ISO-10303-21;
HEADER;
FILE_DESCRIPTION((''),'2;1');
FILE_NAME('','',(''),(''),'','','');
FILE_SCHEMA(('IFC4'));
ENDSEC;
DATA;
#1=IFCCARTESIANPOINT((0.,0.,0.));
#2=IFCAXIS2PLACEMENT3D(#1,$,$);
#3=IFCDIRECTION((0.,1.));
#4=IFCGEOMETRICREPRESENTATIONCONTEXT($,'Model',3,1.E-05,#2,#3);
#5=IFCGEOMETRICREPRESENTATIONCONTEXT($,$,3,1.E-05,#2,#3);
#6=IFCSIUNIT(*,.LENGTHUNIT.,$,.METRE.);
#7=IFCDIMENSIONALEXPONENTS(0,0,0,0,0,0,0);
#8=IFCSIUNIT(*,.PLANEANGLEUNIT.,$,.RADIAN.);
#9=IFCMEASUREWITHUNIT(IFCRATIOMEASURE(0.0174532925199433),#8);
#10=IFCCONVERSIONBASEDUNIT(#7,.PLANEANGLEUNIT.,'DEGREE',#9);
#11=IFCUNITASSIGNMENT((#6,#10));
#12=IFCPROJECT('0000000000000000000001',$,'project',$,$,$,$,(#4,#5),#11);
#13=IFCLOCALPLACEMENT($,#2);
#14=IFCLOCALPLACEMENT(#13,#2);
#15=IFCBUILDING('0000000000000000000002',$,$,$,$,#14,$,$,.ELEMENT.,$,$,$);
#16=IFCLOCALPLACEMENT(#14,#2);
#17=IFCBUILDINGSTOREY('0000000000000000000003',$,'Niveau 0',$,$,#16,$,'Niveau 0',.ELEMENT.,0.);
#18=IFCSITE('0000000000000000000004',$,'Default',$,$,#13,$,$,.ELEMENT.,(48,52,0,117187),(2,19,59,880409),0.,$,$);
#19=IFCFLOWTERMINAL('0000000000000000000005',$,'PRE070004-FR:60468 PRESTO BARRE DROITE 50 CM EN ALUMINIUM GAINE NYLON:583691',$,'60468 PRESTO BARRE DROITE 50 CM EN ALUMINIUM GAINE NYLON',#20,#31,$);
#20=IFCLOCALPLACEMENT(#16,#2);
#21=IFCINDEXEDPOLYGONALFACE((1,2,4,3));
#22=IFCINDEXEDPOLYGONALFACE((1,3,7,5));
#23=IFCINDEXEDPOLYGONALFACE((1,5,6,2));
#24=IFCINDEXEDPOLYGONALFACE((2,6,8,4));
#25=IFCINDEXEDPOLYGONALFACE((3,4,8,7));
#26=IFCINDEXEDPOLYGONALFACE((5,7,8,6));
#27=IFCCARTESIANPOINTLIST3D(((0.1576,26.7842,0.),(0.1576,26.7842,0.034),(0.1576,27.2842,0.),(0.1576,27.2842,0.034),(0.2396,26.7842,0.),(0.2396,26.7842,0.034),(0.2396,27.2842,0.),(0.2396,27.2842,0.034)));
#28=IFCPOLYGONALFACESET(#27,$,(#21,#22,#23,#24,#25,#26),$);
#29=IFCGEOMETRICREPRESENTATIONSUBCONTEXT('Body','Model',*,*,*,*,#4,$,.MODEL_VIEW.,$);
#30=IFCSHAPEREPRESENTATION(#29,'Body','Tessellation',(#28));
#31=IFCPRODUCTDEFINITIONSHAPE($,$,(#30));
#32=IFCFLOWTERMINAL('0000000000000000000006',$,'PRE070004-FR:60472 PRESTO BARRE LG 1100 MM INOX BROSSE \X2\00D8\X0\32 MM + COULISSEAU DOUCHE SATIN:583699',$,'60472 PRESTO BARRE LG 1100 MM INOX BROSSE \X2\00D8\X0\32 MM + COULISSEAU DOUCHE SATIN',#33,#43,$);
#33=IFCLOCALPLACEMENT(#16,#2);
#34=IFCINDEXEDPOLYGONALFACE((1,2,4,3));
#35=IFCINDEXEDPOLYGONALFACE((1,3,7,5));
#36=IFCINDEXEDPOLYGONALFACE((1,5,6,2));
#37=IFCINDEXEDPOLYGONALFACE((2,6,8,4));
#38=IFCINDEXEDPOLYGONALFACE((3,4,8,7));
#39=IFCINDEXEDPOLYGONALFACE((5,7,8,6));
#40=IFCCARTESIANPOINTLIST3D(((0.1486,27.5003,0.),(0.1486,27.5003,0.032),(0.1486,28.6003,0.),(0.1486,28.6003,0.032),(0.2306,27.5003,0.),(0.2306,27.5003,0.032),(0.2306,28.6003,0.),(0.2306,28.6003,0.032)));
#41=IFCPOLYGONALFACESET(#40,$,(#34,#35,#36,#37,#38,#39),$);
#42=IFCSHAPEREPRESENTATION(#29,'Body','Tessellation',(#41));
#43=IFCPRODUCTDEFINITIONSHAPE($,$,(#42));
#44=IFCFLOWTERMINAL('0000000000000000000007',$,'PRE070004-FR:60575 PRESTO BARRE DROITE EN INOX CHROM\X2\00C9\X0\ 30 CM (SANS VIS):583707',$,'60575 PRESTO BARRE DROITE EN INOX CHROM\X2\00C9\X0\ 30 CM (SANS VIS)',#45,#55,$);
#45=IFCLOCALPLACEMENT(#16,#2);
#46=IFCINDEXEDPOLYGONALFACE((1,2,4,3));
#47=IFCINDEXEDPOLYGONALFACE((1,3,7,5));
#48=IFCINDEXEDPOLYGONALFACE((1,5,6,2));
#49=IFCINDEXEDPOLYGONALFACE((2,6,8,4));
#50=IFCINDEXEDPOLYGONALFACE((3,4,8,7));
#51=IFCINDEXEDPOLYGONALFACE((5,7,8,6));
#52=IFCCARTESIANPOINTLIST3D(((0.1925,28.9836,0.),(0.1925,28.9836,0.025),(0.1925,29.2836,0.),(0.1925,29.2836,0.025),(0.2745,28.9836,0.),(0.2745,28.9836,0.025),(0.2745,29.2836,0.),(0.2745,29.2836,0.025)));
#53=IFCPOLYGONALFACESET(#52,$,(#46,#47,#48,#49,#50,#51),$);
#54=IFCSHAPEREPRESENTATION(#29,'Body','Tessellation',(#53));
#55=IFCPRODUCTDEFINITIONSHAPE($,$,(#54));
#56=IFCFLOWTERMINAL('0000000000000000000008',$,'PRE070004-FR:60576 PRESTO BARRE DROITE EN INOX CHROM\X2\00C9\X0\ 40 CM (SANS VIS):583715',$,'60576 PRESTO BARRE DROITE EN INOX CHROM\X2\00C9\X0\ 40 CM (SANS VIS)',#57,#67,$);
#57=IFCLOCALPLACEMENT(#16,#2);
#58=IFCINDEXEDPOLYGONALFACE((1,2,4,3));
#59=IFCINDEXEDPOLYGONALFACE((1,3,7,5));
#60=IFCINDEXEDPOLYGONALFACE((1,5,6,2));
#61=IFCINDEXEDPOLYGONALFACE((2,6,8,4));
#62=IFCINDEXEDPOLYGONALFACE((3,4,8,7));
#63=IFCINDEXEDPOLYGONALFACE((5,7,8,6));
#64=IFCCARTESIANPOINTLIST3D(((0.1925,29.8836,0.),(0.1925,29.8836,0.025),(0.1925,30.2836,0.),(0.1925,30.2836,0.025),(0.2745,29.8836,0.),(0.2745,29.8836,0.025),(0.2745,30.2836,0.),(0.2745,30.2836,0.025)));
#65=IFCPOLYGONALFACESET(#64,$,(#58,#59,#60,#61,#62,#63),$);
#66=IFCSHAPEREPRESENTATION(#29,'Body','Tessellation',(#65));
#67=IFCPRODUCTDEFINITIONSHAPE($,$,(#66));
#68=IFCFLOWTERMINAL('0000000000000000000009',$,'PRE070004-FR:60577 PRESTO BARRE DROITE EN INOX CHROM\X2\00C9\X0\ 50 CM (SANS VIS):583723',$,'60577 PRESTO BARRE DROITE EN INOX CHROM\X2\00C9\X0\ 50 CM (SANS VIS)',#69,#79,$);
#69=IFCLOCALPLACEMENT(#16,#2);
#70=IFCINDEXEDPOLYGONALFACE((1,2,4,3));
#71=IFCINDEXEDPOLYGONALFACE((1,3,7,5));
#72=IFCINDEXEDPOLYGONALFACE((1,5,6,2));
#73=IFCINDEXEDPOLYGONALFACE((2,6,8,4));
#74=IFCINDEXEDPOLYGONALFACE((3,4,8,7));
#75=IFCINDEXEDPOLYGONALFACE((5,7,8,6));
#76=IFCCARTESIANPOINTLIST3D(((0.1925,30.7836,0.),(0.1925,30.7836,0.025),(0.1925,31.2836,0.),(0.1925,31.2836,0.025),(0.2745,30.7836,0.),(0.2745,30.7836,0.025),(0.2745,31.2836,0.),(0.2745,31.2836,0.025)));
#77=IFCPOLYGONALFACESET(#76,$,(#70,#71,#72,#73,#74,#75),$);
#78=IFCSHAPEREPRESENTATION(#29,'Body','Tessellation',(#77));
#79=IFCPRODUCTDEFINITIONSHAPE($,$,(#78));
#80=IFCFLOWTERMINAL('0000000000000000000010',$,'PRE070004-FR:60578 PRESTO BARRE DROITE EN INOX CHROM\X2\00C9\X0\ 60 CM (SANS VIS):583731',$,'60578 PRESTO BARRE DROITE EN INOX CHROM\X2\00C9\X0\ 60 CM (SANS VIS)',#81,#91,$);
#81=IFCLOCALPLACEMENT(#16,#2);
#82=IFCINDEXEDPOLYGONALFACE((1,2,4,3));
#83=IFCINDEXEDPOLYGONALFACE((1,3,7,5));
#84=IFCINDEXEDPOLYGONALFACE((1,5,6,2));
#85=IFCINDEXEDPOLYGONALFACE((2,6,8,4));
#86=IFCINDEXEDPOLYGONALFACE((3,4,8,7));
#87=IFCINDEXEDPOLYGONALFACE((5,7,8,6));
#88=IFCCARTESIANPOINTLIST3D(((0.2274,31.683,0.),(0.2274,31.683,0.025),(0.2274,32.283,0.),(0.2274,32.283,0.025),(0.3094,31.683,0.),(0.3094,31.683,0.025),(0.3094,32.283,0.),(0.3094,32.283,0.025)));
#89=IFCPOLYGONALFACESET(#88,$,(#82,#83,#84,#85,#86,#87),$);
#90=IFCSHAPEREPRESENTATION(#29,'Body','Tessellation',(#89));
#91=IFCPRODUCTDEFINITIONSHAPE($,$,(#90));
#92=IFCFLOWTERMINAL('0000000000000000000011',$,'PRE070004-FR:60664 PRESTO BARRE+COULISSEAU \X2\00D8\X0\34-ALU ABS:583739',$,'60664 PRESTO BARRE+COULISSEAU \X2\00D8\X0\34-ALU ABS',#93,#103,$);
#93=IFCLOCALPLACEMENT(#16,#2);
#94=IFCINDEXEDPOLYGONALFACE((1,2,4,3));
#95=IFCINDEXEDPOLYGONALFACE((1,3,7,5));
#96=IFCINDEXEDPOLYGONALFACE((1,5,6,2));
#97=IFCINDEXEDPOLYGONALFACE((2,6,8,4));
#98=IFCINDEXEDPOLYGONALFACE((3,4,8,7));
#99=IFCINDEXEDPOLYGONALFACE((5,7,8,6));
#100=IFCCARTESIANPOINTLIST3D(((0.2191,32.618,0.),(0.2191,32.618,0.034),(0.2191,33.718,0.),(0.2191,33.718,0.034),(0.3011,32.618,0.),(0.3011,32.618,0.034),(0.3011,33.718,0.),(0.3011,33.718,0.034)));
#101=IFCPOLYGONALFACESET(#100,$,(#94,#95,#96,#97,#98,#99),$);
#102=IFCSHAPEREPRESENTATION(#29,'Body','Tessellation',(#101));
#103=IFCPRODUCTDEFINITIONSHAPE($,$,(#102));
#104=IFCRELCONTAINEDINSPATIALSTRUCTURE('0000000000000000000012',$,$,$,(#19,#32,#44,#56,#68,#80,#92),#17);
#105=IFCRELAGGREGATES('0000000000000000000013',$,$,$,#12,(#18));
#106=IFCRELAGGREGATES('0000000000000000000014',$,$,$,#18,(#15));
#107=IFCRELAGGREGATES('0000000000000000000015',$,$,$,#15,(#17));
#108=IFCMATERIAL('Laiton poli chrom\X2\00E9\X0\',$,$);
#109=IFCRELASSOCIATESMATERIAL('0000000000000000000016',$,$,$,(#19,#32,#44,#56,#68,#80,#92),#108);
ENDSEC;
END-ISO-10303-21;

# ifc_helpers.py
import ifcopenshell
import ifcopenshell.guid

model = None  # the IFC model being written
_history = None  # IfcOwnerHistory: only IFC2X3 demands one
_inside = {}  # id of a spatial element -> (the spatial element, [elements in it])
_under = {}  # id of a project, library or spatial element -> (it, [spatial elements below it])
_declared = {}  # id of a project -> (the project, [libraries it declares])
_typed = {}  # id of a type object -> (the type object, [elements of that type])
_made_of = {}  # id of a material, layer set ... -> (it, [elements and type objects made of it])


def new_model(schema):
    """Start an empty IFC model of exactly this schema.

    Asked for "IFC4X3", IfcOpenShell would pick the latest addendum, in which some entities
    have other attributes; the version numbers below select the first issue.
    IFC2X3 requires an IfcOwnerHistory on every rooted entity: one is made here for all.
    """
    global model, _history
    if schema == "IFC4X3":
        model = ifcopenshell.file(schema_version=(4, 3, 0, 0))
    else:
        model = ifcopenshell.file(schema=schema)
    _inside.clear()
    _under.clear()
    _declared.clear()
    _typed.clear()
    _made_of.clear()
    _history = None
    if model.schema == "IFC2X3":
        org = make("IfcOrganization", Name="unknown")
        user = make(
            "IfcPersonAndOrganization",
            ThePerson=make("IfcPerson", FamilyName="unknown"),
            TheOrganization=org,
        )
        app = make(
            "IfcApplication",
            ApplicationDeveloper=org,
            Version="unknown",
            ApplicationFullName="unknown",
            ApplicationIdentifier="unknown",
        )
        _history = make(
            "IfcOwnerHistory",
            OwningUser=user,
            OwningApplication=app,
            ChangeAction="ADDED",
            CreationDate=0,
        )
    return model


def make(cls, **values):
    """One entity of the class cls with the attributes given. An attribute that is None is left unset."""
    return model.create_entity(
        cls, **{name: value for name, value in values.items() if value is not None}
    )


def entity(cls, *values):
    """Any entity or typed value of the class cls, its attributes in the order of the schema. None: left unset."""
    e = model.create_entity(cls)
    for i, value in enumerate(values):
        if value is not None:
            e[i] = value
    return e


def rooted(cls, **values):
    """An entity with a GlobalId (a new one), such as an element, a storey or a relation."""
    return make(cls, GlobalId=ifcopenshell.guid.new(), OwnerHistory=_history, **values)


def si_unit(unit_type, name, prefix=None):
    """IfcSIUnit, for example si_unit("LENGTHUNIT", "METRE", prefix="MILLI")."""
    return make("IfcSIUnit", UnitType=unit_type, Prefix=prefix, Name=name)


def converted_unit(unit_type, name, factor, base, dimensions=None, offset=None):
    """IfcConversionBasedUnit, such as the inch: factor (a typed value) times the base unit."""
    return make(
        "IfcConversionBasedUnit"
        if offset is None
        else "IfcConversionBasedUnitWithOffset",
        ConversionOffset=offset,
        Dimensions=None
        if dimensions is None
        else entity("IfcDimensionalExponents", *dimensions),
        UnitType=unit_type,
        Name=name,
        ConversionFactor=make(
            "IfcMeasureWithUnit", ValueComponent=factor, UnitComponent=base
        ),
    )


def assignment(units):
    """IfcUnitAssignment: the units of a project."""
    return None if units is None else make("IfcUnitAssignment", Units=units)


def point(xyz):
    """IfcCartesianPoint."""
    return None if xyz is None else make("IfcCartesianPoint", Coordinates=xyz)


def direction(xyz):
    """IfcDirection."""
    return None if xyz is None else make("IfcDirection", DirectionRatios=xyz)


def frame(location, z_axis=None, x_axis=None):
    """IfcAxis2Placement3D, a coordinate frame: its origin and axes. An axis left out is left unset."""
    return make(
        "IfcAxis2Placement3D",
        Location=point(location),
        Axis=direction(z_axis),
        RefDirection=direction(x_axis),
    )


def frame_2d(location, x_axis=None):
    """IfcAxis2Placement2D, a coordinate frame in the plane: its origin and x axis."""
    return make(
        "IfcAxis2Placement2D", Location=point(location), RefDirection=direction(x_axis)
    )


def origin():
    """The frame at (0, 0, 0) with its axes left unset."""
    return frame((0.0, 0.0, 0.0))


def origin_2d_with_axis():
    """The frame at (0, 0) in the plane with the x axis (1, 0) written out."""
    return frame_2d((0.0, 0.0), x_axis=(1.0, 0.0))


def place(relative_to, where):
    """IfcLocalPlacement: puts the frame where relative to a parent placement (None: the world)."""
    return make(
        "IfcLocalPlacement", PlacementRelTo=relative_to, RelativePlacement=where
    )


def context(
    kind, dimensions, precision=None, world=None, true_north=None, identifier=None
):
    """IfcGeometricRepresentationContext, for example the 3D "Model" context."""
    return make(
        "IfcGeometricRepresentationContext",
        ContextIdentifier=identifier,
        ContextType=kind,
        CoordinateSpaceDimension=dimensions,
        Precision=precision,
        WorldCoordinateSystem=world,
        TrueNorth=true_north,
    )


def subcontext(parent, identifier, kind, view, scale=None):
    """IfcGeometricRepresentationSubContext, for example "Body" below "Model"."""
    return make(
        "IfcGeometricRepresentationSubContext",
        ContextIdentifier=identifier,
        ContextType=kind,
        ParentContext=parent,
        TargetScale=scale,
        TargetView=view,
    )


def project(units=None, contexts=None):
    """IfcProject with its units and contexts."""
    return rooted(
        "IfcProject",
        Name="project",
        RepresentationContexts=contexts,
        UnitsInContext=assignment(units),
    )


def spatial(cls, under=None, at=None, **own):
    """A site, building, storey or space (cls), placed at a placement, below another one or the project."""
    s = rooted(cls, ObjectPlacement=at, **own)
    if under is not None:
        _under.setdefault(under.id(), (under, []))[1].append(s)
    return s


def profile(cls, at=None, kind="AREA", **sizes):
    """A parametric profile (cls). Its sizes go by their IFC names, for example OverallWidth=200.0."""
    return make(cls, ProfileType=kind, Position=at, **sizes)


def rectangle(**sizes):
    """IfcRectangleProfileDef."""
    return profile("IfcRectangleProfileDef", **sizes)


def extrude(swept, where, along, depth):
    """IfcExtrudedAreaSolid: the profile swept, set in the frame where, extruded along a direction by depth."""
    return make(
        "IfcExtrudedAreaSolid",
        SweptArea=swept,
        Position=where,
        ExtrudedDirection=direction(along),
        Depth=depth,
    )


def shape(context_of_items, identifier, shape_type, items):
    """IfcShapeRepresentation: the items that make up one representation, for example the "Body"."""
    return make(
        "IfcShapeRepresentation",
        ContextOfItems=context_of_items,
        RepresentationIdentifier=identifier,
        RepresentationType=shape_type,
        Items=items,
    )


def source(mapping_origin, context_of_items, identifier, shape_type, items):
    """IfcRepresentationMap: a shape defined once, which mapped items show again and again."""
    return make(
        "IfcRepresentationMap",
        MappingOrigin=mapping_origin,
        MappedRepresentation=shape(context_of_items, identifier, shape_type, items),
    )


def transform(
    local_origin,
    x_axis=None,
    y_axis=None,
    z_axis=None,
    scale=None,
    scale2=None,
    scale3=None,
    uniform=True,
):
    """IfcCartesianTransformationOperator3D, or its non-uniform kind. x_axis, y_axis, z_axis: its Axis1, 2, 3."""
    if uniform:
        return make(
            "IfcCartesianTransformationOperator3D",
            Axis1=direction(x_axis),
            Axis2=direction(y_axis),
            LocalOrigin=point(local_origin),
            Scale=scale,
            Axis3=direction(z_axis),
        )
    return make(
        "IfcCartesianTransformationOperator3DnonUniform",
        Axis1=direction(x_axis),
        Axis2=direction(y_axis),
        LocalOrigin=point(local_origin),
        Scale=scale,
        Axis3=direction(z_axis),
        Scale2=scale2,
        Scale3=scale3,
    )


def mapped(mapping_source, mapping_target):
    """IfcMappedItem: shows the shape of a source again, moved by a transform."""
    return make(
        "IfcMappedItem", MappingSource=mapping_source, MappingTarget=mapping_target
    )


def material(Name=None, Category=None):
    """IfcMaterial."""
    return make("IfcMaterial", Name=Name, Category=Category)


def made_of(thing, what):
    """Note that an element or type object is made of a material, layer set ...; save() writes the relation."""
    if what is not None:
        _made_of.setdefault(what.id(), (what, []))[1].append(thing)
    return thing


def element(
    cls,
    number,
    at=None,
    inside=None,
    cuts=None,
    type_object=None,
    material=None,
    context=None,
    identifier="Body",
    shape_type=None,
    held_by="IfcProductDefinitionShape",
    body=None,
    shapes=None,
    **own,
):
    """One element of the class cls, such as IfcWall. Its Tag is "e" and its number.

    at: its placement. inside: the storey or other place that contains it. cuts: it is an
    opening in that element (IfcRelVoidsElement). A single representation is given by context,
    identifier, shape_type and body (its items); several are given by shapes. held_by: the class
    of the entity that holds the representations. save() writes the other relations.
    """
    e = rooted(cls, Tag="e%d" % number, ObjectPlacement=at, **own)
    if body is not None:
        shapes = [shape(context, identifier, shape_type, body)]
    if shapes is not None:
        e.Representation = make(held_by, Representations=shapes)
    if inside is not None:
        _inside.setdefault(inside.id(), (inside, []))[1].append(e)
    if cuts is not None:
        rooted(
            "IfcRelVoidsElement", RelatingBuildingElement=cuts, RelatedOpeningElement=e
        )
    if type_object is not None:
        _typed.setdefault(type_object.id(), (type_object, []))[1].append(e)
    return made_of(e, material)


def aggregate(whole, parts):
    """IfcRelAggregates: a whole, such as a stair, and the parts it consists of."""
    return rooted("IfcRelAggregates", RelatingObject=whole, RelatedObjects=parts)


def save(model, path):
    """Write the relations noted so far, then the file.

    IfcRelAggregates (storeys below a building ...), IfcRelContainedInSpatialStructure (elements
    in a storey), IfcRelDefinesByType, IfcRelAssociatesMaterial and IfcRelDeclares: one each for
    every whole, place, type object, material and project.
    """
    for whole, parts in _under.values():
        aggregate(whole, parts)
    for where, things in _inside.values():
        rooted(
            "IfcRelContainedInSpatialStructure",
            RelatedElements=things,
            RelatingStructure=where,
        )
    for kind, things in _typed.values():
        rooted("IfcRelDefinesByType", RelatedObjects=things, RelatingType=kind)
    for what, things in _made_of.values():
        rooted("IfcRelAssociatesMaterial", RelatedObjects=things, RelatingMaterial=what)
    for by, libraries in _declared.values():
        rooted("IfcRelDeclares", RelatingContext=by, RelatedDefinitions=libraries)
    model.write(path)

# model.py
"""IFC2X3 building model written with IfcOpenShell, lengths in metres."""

from ifc_helpers import new_model, entity, si_unit, converted_unit, direction, frame, origin, origin_2d_with_axis, place, context, subcontext, project, spatial, rectangle, extrude, source, transform, mapped, material, element, save


model = new_model("IFC2X3")

# Units and contexts
model_context = context("Model", 3, precision=1e-05, world=origin(), true_north=direction((0.0, 1.0)))
context_of_model = context(None, 3, precision=1e-05, world=origin(), true_north=direction((0.0, 1.0)))
body_context = subcontext(model_context, "Body", "Model", "MODEL_VIEW")
ifc_project = project(units=[si_unit("LENGTHUNIT", "METRE"), converted_unit("PLANEANGLEUNIT", "DEGREE", entity("IfcRatioMeasure", 0.0174532925199433), si_unit("PLANEANGLEUNIT", "RADIAN"), dimensions=[0, 0, 0, 0, 0, 0, 0])], contexts=[model_context, context_of_model])

# Site, building, storey
site_placement = place(None, origin())
site = spatial("IfcSite", under=ifc_project, at=site_placement, Name="Default", CompositionType="ELEMENT", RefLatitude=(48, 52, 0, 117187), RefLongitude=(2, 19, 59, 880409), RefElevation=0.0)
building_placement = place(site_placement, origin())
building = spatial("IfcBuilding", under=site, at=building_placement, CompositionType="ELEMENT")
storey_placement = place(building_placement, origin())
storey = spatial("IfcBuildingStorey", under=building, at=storey_placement, Name="Niveau 0", LongName="Niveau 0", CompositionType="ELEMENT", Elevation=0.0)

# Flow terminals
ifc_material = material(Name="Laiton poli chromé")
shared_shape_1 = source(origin(), body_context, "Body", "SweptSolid", [
    extrude(rectangle(XDim=0.082, YDim=0.5, at=origin_2d_with_axis()), frame((0.041, -0.25, 0.0), z_axis=(0.0, 0.0, 1.0), x_axis=(-1.0, 0.0, 0.0)), (0.0, 0.0, 1.0), 0.034),
])
flow_terminal_1_placement = place(storey_placement, frame((0.1576, 27.2842, 0.0)))
element("IfcFlowTerminal", 1, at=flow_terminal_1_placement, inside=storey, material=ifc_material, Name="PRE070004-FR:60468 PRESTO BARRE DROITE 50 CM EN ALUMINIUM GAINE NYLON:583691", ObjectType="60468 PRESTO BARRE DROITE 50 CM EN ALUMINIUM GAINE NYLON", context=body_context, shape_type="MappedRepresentation", body=[
    mapped(shared_shape_1, transform((0.0, 0.0, 0.0), scale=1.0)),
])
shared_shape_2 = source(origin(), body_context, "Body", "SweptSolid", [
    extrude(rectangle(XDim=0.082, YDim=1.1, at=origin_2d_with_axis()), frame((0.041, -0.55, 0.0), z_axis=(0.0, 0.0, 1.0), x_axis=(-1.0, 0.0, 0.0)), (0.0, 0.0, 1.0), 0.032),
])
flow_terminal_2_placement = place(storey_placement, frame((0.1486, 28.6003, 0.0)))
element("IfcFlowTerminal", 2, at=flow_terminal_2_placement, inside=storey, material=ifc_material, Name="PRE070004-FR:60472 PRESTO BARRE LG 1100 MM INOX BROSSE Ø32 MM + COULISSEAU DOUCHE SATIN:583699", ObjectType="60472 PRESTO BARRE LG 1100 MM INOX BROSSE Ø32 MM + COULISSEAU DOUCHE SATIN", context=body_context, shape_type="MappedRepresentation", body=[
    mapped(shared_shape_2, transform((0.0, 0.0, 0.0), scale=1.0)),
])
shared_shape_3 = source(origin(), body_context, "Body", "SweptSolid", [
    extrude(rectangle(XDim=0.082, YDim=0.3, at=origin_2d_with_axis()), frame((0.041, -0.15, 0.0), z_axis=(0.0, 0.0, 1.0), x_axis=(-1.0, 0.0, 0.0)), (0.0, 0.0, 1.0), 0.025),
])
flow_terminal_3_placement = place(storey_placement, frame((0.1925, 29.2836, 0.0)))
element("IfcFlowTerminal", 3, at=flow_terminal_3_placement, inside=storey, material=ifc_material, Name="PRE070004-FR:60575 PRESTO BARRE DROITE EN INOX CHROMÉ 30 CM (SANS VIS):583707", ObjectType="60575 PRESTO BARRE DROITE EN INOX CHROMÉ 30 CM (SANS VIS)", context=body_context, shape_type="MappedRepresentation", body=[
    mapped(shared_shape_3, transform((0.0, 0.0, 0.0), scale=1.0)),
])
shared_shape_4 = source(origin(), body_context, "Body", "SweptSolid", [
    extrude(rectangle(XDim=0.082, YDim=0.4, at=origin_2d_with_axis()), frame((0.041, -0.2, 0.0), z_axis=(0.0, 0.0, 1.0), x_axis=(-1.0, 0.0, 0.0)), (0.0, 0.0, 1.0), 0.025),
])
flow_terminal_4_placement = place(storey_placement, frame((0.1925, 30.2836, 0.0)))
element("IfcFlowTerminal", 4, at=flow_terminal_4_placement, inside=storey, material=ifc_material, Name="PRE070004-FR:60576 PRESTO BARRE DROITE EN INOX CHROMÉ 40 CM (SANS VIS):583715", ObjectType="60576 PRESTO BARRE DROITE EN INOX CHROMÉ 40 CM (SANS VIS)", context=body_context, shape_type="MappedRepresentation", body=[
    mapped(shared_shape_4, transform((0.0, 0.0, 0.0), scale=1.0)),
])
shared_shape_5 = source(origin(), body_context, "Body", "SweptSolid", [
    extrude(rectangle(XDim=0.082, YDim=0.5, at=origin_2d_with_axis()), frame((0.041, -0.25, 0.0), z_axis=(0.0, 0.0, 1.0), x_axis=(-1.0, 0.0, 0.0)), (0.0, 0.0, 1.0), 0.025),
])
flow_terminal_5_placement = place(storey_placement, frame((0.1925, 31.2836, 0.0)))
element("IfcFlowTerminal", 5, at=flow_terminal_5_placement, inside=storey, material=ifc_material, Name="PRE070004-FR:60577 PRESTO BARRE DROITE EN INOX CHROMÉ 50 CM (SANS VIS):583723", ObjectType="60577 PRESTO BARRE DROITE EN INOX CHROMÉ 50 CM (SANS VIS)", context=body_context, shape_type="MappedRepresentation", body=[
    mapped(shared_shape_5, transform((0.0, 0.0, 0.0), scale=1.0)),
])
shared_shape_6 = source(origin(), body_context, "Body", "SweptSolid", [
    extrude(rectangle(XDim=0.082, YDim=0.6, at=origin_2d_with_axis()), frame((0.041, -0.3, 0.0), z_axis=(0.0, 0.0, 1.0), x_axis=(-1.0, 0.0, 0.0)), (0.0, 0.0, 1.0), 0.025),
])
flow_terminal_6_placement = place(storey_placement, frame((0.2274, 32.283, 0.0)))
element("IfcFlowTerminal", 6, at=flow_terminal_6_placement, inside=storey, material=ifc_material, Name="PRE070004-FR:60578 PRESTO BARRE DROITE EN INOX CHROMÉ 60 CM (SANS VIS):583731", ObjectType="60578 PRESTO BARRE DROITE EN INOX CHROMÉ 60 CM (SANS VIS)", context=body_context, shape_type="MappedRepresentation", body=[
    mapped(shared_shape_6, transform((0.0, 0.0, 0.0), scale=1.0)),
])
shared_shape_7 = source(origin(), body_context, "Body", "SweptSolid", [
    extrude(rectangle(XDim=0.082, YDim=1.1, at=origin_2d_with_axis()), frame((0.041, -0.55, 0.0), z_axis=(0.0, 0.0, 1.0), x_axis=(-1.0, 0.0, 0.0)), (0.0, 0.0, 1.0), 0.034),
])
flow_terminal_7_placement = place(storey_placement, frame((0.2191, 33.718, 0.0)))
element("IfcFlowTerminal", 7, at=flow_terminal_7_placement, inside=storey, material=ifc_material, Name="PRE070004-FR:60664 PRESTO BARRE+COULISSEAU Ø34-ALU ABS:583739", ObjectType="60664 PRESTO BARRE+COULISSEAU Ø34-ALU ABS", context=body_context, shape_type="MappedRepresentation", body=[
    mapped(shared_shape_7, transform((0.0, 0.0, 0.0), scale=1.0)),
])

save(model, "model.ifc")
